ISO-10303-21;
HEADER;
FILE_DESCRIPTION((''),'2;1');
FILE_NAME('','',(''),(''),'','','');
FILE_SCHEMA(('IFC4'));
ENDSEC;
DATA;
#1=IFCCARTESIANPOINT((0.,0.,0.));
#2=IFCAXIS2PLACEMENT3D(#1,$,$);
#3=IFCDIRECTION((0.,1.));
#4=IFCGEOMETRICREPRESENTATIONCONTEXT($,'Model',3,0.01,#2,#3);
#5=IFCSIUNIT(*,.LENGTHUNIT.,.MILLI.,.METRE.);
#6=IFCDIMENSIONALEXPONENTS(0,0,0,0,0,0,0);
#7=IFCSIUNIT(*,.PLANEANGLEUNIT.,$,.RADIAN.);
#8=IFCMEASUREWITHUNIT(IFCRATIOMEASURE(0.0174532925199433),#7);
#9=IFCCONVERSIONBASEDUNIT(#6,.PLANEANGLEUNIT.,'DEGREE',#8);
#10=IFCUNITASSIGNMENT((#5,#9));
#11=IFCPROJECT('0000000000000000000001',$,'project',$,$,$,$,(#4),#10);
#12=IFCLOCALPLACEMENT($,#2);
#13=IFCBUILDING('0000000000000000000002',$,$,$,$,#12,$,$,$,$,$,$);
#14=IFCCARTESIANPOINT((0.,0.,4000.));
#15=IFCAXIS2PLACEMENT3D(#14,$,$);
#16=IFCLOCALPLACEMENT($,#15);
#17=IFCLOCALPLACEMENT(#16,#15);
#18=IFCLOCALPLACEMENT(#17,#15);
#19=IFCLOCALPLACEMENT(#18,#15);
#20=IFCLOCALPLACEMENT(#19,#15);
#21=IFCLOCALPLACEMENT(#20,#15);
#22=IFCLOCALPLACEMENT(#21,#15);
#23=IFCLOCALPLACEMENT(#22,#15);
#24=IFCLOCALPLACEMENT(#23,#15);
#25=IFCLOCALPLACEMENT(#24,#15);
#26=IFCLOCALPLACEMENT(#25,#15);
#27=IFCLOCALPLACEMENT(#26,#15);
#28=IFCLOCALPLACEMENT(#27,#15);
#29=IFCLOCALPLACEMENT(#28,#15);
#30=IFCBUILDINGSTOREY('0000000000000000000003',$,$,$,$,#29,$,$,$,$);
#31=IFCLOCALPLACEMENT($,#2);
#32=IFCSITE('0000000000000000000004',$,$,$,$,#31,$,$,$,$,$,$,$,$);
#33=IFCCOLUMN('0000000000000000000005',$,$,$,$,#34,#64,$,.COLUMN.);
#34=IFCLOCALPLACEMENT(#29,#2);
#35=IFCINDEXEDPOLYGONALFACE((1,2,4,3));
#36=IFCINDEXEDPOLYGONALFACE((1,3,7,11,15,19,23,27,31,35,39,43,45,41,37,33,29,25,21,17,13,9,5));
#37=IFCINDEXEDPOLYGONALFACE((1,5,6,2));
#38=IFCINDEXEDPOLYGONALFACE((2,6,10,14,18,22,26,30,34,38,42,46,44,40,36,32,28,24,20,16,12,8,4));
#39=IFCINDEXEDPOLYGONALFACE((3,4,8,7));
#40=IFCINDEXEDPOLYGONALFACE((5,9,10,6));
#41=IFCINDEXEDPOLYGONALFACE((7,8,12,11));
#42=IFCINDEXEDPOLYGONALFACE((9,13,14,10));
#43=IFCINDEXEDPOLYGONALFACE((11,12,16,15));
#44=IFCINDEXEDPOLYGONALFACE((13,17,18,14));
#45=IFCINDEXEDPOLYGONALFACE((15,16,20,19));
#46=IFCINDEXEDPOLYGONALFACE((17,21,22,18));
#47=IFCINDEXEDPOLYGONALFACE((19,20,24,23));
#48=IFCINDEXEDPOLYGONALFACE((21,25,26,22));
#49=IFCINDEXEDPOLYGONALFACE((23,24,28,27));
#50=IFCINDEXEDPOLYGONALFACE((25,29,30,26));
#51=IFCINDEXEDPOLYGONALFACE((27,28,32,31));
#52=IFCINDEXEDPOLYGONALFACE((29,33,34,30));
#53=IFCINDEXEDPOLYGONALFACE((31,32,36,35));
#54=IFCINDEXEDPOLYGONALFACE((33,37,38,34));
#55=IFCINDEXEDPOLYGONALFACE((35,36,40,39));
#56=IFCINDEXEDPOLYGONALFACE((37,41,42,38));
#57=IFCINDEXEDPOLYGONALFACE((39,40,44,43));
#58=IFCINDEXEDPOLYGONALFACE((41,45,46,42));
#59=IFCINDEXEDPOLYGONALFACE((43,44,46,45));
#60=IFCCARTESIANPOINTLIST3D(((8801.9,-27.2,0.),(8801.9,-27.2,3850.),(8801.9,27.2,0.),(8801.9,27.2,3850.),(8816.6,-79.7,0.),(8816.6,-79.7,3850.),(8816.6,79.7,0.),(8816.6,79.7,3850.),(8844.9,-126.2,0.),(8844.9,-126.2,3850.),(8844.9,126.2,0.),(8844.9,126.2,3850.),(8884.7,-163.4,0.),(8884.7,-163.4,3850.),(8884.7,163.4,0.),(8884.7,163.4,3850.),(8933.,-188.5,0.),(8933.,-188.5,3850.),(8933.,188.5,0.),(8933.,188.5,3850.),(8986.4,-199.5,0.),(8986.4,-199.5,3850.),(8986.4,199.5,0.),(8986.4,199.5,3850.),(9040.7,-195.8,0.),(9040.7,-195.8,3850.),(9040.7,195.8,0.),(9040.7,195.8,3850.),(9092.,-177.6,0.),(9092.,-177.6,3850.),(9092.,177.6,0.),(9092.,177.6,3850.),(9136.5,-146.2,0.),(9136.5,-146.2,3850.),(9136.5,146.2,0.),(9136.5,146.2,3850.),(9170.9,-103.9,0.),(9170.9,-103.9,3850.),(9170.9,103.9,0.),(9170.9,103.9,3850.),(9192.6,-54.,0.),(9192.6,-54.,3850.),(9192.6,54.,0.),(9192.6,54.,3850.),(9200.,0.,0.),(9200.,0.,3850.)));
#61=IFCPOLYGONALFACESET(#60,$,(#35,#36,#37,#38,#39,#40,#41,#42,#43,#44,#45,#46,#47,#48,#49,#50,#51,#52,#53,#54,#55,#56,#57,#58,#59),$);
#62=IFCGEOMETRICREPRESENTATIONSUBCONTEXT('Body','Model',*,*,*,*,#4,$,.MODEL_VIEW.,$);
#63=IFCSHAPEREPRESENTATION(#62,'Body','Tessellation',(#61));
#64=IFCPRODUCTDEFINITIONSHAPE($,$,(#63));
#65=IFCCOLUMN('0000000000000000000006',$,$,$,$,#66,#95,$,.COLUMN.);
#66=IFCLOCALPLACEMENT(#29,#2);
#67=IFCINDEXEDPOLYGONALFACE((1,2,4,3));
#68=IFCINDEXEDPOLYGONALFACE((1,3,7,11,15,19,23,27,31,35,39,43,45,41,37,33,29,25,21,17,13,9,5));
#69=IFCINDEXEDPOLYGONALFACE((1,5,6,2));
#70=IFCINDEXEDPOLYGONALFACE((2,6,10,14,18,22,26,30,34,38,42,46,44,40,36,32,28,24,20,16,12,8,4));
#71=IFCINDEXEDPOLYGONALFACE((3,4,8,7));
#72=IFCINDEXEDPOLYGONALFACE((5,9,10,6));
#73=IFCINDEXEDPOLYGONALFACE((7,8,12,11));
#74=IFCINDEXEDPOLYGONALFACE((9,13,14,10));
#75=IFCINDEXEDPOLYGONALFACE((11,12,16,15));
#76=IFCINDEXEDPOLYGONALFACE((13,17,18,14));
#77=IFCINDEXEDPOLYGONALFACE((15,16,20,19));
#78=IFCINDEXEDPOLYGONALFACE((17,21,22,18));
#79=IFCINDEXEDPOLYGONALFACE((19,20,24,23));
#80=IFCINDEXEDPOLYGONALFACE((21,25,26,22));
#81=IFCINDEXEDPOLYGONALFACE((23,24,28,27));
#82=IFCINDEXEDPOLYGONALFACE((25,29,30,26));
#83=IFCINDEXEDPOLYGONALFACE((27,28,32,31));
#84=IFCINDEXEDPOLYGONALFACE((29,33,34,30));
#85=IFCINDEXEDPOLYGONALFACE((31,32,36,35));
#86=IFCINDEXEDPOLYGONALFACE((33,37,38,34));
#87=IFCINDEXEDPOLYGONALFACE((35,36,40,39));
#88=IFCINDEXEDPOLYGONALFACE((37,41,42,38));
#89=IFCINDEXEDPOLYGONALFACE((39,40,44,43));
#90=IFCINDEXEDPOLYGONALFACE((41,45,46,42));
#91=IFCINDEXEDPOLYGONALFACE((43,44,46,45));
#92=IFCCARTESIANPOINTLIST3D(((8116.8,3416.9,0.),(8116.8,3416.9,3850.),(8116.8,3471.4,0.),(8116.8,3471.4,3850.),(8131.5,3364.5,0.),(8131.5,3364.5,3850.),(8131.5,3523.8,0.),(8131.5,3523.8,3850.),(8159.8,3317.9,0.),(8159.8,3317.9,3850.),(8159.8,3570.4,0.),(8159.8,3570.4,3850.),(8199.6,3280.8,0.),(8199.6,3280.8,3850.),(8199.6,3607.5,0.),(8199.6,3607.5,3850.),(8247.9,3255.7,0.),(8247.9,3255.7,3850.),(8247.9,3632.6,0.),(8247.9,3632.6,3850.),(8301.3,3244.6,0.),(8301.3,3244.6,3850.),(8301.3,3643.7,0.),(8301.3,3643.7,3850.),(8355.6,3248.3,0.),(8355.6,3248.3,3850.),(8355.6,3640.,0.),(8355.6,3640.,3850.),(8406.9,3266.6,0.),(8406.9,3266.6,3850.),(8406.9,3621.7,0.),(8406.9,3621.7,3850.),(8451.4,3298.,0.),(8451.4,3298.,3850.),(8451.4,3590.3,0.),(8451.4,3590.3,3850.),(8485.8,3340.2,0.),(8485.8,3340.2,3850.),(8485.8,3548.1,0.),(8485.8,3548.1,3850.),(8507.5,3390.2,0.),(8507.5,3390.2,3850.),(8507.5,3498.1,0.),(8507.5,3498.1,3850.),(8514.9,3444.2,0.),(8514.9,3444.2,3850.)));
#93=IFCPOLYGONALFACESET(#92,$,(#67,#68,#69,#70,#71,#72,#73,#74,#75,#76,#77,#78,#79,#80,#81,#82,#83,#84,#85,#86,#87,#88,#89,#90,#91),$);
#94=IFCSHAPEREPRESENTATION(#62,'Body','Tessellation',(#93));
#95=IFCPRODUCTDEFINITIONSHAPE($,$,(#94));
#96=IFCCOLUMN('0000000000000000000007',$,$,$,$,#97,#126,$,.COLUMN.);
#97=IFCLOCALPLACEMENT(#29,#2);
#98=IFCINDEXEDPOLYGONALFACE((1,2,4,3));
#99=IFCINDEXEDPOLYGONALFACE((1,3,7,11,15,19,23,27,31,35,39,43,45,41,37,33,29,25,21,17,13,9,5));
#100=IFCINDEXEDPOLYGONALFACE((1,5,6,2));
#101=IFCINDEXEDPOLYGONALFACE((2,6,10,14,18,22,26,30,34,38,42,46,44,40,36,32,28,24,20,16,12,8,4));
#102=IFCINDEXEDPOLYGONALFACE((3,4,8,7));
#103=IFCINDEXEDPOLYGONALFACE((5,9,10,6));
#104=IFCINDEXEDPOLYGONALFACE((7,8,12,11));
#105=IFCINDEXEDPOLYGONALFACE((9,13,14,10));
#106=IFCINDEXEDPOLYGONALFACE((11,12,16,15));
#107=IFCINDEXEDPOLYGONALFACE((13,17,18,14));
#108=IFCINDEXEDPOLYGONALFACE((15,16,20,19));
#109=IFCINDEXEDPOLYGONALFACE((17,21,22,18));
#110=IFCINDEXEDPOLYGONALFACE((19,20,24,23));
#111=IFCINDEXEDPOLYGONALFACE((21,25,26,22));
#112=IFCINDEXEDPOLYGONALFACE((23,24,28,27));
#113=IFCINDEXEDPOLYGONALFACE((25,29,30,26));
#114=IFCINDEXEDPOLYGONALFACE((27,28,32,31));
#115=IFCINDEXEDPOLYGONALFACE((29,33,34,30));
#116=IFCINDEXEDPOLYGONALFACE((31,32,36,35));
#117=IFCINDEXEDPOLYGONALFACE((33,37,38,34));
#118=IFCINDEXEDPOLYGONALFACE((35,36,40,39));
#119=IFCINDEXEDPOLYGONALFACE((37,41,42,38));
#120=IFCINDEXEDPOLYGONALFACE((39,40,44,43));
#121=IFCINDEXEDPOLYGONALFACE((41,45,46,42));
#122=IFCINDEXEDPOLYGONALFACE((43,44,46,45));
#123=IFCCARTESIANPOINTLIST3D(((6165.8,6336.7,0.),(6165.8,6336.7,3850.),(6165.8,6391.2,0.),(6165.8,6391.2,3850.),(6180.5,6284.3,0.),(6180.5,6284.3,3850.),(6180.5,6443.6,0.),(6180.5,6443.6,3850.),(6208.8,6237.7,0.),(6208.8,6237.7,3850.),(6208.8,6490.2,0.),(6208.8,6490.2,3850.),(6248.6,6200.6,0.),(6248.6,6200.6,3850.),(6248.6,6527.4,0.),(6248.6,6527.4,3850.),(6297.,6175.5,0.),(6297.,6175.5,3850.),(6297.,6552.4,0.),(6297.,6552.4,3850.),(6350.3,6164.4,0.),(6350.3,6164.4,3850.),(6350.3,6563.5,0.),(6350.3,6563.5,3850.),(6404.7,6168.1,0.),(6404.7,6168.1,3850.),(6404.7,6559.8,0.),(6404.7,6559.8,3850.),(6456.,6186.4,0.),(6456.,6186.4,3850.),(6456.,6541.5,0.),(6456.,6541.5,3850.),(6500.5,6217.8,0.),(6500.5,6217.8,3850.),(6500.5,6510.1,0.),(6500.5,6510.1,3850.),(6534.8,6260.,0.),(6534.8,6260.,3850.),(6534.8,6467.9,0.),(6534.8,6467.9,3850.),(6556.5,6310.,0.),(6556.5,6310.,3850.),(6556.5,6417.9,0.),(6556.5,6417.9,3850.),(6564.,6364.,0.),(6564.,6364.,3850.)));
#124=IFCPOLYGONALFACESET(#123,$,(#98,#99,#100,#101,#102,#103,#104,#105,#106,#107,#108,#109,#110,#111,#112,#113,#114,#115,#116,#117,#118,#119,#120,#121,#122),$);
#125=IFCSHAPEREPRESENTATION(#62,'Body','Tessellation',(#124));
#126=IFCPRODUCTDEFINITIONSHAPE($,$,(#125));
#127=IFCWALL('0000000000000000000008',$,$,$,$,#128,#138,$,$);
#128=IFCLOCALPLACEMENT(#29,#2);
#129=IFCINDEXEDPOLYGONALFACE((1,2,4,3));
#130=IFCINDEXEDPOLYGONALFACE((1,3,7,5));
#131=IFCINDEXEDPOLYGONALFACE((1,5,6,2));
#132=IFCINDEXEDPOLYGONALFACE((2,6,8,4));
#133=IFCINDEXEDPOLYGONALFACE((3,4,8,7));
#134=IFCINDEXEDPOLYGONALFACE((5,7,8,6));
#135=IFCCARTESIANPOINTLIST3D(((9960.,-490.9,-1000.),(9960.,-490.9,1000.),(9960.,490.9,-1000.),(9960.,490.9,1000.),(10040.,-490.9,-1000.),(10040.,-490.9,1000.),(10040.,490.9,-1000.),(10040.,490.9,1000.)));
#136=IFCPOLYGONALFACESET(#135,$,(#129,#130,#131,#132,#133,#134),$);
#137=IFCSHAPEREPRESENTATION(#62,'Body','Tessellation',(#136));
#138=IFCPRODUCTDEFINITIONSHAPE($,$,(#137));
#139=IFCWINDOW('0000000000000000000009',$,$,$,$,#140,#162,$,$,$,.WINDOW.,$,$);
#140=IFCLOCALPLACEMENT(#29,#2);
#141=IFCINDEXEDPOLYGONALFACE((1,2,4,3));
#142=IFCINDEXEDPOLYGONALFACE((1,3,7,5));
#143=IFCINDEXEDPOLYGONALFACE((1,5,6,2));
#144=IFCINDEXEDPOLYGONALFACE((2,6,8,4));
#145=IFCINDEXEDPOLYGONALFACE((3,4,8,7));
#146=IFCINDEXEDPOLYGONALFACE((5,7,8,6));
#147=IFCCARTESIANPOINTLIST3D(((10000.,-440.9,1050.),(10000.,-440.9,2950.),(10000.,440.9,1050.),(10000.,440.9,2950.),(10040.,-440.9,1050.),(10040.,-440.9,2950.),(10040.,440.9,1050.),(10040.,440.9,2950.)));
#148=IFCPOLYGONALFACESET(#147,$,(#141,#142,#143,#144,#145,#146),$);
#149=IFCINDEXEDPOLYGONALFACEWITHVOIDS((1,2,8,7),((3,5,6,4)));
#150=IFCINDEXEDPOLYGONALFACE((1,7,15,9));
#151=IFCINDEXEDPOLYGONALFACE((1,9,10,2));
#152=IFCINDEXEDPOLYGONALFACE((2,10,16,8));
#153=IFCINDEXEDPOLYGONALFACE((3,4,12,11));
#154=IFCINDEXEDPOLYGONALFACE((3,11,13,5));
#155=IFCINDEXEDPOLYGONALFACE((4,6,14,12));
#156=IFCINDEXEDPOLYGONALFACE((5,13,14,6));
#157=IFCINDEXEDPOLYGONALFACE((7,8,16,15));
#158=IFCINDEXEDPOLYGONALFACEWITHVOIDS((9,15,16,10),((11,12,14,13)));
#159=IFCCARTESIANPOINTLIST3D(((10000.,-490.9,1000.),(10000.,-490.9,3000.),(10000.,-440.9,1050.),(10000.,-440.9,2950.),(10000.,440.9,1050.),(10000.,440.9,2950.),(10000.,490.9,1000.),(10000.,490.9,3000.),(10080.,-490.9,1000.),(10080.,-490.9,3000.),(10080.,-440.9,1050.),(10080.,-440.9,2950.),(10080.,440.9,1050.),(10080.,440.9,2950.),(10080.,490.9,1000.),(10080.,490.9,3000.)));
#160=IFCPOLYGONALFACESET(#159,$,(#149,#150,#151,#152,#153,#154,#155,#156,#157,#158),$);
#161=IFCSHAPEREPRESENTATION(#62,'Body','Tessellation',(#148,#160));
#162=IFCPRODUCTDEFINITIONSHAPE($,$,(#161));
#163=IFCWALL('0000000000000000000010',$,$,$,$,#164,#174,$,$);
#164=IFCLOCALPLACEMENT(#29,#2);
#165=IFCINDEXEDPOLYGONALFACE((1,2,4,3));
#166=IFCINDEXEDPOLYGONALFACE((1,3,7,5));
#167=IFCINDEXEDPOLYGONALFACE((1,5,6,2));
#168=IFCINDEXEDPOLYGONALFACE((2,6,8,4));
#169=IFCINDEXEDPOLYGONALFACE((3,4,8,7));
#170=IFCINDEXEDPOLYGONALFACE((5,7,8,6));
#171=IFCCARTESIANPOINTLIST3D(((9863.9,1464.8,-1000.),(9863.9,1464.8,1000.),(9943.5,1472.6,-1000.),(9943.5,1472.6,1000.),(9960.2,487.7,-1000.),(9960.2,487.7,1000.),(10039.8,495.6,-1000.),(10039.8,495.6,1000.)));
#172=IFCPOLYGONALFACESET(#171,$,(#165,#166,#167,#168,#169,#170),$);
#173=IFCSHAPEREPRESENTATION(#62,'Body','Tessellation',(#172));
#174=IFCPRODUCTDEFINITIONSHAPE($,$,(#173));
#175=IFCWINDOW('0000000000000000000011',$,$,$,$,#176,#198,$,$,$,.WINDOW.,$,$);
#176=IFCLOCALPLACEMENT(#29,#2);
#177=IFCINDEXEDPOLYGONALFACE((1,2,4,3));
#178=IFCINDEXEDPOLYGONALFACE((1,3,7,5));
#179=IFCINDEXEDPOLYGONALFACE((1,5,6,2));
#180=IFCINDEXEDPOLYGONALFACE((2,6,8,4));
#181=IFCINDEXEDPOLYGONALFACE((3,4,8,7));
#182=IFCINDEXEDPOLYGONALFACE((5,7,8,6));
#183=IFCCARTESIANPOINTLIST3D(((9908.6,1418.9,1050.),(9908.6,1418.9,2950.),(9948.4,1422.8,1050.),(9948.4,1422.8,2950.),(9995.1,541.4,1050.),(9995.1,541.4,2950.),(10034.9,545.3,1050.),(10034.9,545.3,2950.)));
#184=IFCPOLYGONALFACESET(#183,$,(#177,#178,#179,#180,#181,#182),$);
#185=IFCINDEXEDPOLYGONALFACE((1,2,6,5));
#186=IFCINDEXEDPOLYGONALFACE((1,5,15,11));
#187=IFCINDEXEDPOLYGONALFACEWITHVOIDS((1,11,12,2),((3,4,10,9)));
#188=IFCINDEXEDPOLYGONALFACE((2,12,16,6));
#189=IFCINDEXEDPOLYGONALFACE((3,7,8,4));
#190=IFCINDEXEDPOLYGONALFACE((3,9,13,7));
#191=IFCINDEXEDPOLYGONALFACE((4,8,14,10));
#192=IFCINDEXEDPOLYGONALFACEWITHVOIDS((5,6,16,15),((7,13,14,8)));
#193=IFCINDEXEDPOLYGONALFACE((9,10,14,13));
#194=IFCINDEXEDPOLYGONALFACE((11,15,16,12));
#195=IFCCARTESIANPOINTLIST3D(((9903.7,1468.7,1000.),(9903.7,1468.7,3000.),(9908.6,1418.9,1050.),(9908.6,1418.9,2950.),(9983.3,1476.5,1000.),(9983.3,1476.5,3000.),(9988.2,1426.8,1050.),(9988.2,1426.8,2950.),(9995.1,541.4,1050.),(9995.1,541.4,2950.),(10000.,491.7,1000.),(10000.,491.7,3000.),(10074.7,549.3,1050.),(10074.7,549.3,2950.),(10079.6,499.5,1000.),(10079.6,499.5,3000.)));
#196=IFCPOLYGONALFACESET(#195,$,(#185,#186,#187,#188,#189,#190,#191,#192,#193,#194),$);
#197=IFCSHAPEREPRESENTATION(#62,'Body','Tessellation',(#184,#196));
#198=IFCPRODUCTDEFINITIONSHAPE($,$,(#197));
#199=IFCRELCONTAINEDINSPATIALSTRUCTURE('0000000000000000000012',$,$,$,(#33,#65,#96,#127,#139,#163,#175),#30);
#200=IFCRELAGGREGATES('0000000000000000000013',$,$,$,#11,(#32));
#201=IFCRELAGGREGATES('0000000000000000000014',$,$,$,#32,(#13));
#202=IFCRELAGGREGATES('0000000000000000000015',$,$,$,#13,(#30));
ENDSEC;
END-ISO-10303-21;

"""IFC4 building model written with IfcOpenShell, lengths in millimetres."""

from ifc_helpers import new_model, entity, si_unit, converted_unit, direction, frame, origin, origin_2d, place, context, subcontext, project, spatial, rectangle, circle, extrude, element, save


model = new_model("IFC4")

# Units and contexts
model_context = context("Model", 3, precision=0.01, world=origin(), true_north=direction((0.0, 1.0)))
body_context = subcontext(model_context, "Body", "Model", "MODEL_VIEW")
ifc_project = project(units=[si_unit("LENGTHUNIT", "METRE", prefix="MILLI"), converted_unit("PLANEANGLEUNIT", "DEGREE", entity("IfcRatioMeasure", 0.0174532925199433), si_unit("PLANEANGLEUNIT", "RADIAN"), dimensions=[0, 0, 0, 0, 0, 0, 0])], contexts=[model_context])

# Site, building, storey
site_placement = place(None, origin())
site = spatial("IfcSite", under=ifc_project, at=site_placement)
building_placement = place(None, origin())
building = spatial("IfcBuilding", under=site, at=building_placement)
placement_1 = place(None, frame((0.0, 0.0, 4000.0)))
placement_2 = place(placement_1, frame((0.0, 0.0, 4000.0)))
placement_3 = place(placement_2, frame((0.0, 0.0, 4000.0)))
placement_4 = place(placement_3, frame((0.0, 0.0, 4000.0)))
placement_5 = place(placement_4, frame((0.0, 0.0, 4000.0)))
placement_6 = place(placement_5, frame((0.0, 0.0, 4000.0)))
placement_7 = place(placement_6, frame((0.0, 0.0, 4000.0)))
placement_8 = place(placement_7, frame((0.0, 0.0, 4000.0)))
placement_9 = place(placement_8, frame((0.0, 0.0, 4000.0)))
placement_10 = place(placement_9, frame((0.0, 0.0, 4000.0)))
placement_11 = place(placement_10, frame((0.0, 0.0, 4000.0)))
placement_12 = place(placement_11, frame((0.0, 0.0, 4000.0)))
placement_13 = place(placement_12, frame((0.0, 0.0, 4000.0)))
storey_placement = place(placement_13, frame((0.0, 0.0, 4000.0)))
storey = spatial("IfcBuildingStorey", under=building, at=storey_placement)

# Columns
for number, where in (
    (1, (9000.0, 0.0, 0.0)),
    (2, (8314.9, 3444.2, 0.0)),
    (3, (6364.0, 6364.0, 0.0)),
):
    element("IfcColumn", number, at=place(storey_placement, frame(where)), inside=storey, PredefinedType="COLUMN", context=body_context, shape_type="SweptSolid", body=[
        extrude(circle(Radius=200.0, at=origin_2d()), origin(), (0.0, 0.0, 1.0), 3850.0),
    ])

# Wall
wall_1_placement = place(storey_placement, frame((10000.0, 0.0, -1000.0), z_axis=(0.0, 0.0, 1.0), x_axis=(0.0, 10000.0, 0.0)))
element("IfcWall", 4, at=wall_1_placement, inside=storey, context=body_context, shape_type="SweptSolid", body=[
    extrude(rectangle(XDim=981.7, YDim=80.0, at=origin_2d()), origin(), (0.0, 0.0, 1.0), 2000.0),
])

# Window
cartesian_point_1 = entity("IfcCartesianPoint", [-440.9, -950.0])
shared_polyline = entity("IfcPolyline", [cartesian_point_1, entity("IfcCartesianPoint", [-440.9, 950.0]), entity("IfcCartesianPoint", [-440.9, 950.0]), entity("IfcCartesianPoint", [440.9, 950.0]), entity("IfcCartesianPoint", [440.9, 950.0]), entity("IfcCartesianPoint", [440.9, -950.0]), entity("IfcCartesianPoint", [440.9, -950.0]), entity("IfcCartesianPoint", [-440.9, -950.0]), cartesian_point_1])
window_1_placement = place(storey_placement, frame((10000.0, 0.0, 2000.0), z_axis=(0.0, 0.0, 1.0), x_axis=(0.0, 10000.0, 0.0)))
cartesian_point_2 = entity("IfcCartesianPoint", [-490.9, -1000.0])
element("IfcWindow", 5, at=window_1_placement, inside=storey, PredefinedType="WINDOW", context=body_context, shape_type="SweptSolid", body=[
    entity("IfcExtrudedAreaSolid", entity("IfcArbitraryClosedProfileDef", "AREA", None, shared_polyline), entity("IfcAxis2Placement3D", entity("IfcCartesianPoint", [0.0, 0.0, 0.0]), entity("IfcDirection", [0.0, -1.0, 0.0]), entity("IfcDirection", [1.0, 0.0, 0.0])), entity("IfcDirection", [0.0, 0.0, 1.0]), 40.0),
    entity("IfcExtrudedAreaSolid", entity("IfcArbitraryProfileDefWithVoids", "AREA", None, entity("IfcPolyline", [cartesian_point_2, entity("IfcCartesianPoint", [-490.9, 1000.0]), entity("IfcCartesianPoint", [-490.9, 1000.0]), entity("IfcCartesianPoint", [490.9, 1000.0]), entity("IfcCartesianPoint", [490.9, 1000.0]), entity("IfcCartesianPoint", [490.9, -1000.0]), entity("IfcCartesianPoint", [490.9, -1000.0]), entity("IfcCartesianPoint", [-490.9, -1000.0]), cartesian_point_2]), [shared_polyline]), entity("IfcAxis2Placement3D", entity("IfcCartesianPoint", [0.0, 0.0, 0.0]), entity("IfcDirection", [0.0, -1.0, 0.0]), entity("IfcDirection", [1.0, 0.0, 0.0])), entity("IfcDirection", [0.0, 0.0, 1.0]), 80.0),
])

# Wall
wall_2_placement = place(storey_placement, frame((9951.8, 980.2, -1000.0), z_axis=(0.0, 0.0, 1.0), x_axis=(-980.17143, 9951.847264, 0.0)))
element("IfcWall", 6, at=wall_2_placement, inside=storey, context=body_context, shape_type="SweptSolid", body=[
    extrude(rectangle(XDim=981.7, YDim=80.0, at=origin_2d()), origin(), (0.0, 0.0, 1.0), 2000.0),
])

# Window
window_2_placement = place(storey_placement, frame((9951.8, 980.2, 2000.0), z_axis=(0.0, 0.0, 1.0), x_axis=(-980.17143, 9951.847264, 0.0)))
cartesian_point_3 = entity("IfcCartesianPoint", [-490.9, -1000.0])
element("IfcWindow", 7, at=window_2_placement, inside=storey, PredefinedType="WINDOW", context=body_context, shape_type="SweptSolid", body=[
    entity("IfcExtrudedAreaSolid", entity("IfcArbitraryClosedProfileDef", "AREA", None, shared_polyline), entity("IfcAxis2Placement3D", entity("IfcCartesianPoint", [0.0, 0.0, 0.0]), entity("IfcDirection", [0.0, -1.0, 0.0]), entity("IfcDirection", [1.0, 0.0, 0.0])), entity("IfcDirection", [0.0, 0.0, 1.0]), 40.0),
    entity("IfcExtrudedAreaSolid", entity("IfcArbitraryProfileDefWithVoids", "AREA", None, entity("IfcPolyline", [cartesian_point_3, entity("IfcCartesianPoint", [-490.9, 1000.0]), entity("IfcCartesianPoint", [-490.9, 1000.0]), entity("IfcCartesianPoint", [490.9, 1000.0]), entity("IfcCartesianPoint", [490.9, 1000.0]), entity("IfcCartesianPoint", [490.9, -1000.0]), entity("IfcCartesianPoint", [490.9, -1000.0]), entity("IfcCartesianPoint", [-490.9, -1000.0]), cartesian_point_3]), [shared_polyline]), entity("IfcAxis2Placement3D", entity("IfcCartesianPoint", [0.0, 0.0, 0.0]), entity("IfcDirection", [0.0, -1.0, 0.0]), entity("IfcDirection", [1.0, 0.0, 0.0])), entity("IfcDirection", [0.0, 0.0, 1.0]), 80.0),
])

save(model, "model.ifc")
